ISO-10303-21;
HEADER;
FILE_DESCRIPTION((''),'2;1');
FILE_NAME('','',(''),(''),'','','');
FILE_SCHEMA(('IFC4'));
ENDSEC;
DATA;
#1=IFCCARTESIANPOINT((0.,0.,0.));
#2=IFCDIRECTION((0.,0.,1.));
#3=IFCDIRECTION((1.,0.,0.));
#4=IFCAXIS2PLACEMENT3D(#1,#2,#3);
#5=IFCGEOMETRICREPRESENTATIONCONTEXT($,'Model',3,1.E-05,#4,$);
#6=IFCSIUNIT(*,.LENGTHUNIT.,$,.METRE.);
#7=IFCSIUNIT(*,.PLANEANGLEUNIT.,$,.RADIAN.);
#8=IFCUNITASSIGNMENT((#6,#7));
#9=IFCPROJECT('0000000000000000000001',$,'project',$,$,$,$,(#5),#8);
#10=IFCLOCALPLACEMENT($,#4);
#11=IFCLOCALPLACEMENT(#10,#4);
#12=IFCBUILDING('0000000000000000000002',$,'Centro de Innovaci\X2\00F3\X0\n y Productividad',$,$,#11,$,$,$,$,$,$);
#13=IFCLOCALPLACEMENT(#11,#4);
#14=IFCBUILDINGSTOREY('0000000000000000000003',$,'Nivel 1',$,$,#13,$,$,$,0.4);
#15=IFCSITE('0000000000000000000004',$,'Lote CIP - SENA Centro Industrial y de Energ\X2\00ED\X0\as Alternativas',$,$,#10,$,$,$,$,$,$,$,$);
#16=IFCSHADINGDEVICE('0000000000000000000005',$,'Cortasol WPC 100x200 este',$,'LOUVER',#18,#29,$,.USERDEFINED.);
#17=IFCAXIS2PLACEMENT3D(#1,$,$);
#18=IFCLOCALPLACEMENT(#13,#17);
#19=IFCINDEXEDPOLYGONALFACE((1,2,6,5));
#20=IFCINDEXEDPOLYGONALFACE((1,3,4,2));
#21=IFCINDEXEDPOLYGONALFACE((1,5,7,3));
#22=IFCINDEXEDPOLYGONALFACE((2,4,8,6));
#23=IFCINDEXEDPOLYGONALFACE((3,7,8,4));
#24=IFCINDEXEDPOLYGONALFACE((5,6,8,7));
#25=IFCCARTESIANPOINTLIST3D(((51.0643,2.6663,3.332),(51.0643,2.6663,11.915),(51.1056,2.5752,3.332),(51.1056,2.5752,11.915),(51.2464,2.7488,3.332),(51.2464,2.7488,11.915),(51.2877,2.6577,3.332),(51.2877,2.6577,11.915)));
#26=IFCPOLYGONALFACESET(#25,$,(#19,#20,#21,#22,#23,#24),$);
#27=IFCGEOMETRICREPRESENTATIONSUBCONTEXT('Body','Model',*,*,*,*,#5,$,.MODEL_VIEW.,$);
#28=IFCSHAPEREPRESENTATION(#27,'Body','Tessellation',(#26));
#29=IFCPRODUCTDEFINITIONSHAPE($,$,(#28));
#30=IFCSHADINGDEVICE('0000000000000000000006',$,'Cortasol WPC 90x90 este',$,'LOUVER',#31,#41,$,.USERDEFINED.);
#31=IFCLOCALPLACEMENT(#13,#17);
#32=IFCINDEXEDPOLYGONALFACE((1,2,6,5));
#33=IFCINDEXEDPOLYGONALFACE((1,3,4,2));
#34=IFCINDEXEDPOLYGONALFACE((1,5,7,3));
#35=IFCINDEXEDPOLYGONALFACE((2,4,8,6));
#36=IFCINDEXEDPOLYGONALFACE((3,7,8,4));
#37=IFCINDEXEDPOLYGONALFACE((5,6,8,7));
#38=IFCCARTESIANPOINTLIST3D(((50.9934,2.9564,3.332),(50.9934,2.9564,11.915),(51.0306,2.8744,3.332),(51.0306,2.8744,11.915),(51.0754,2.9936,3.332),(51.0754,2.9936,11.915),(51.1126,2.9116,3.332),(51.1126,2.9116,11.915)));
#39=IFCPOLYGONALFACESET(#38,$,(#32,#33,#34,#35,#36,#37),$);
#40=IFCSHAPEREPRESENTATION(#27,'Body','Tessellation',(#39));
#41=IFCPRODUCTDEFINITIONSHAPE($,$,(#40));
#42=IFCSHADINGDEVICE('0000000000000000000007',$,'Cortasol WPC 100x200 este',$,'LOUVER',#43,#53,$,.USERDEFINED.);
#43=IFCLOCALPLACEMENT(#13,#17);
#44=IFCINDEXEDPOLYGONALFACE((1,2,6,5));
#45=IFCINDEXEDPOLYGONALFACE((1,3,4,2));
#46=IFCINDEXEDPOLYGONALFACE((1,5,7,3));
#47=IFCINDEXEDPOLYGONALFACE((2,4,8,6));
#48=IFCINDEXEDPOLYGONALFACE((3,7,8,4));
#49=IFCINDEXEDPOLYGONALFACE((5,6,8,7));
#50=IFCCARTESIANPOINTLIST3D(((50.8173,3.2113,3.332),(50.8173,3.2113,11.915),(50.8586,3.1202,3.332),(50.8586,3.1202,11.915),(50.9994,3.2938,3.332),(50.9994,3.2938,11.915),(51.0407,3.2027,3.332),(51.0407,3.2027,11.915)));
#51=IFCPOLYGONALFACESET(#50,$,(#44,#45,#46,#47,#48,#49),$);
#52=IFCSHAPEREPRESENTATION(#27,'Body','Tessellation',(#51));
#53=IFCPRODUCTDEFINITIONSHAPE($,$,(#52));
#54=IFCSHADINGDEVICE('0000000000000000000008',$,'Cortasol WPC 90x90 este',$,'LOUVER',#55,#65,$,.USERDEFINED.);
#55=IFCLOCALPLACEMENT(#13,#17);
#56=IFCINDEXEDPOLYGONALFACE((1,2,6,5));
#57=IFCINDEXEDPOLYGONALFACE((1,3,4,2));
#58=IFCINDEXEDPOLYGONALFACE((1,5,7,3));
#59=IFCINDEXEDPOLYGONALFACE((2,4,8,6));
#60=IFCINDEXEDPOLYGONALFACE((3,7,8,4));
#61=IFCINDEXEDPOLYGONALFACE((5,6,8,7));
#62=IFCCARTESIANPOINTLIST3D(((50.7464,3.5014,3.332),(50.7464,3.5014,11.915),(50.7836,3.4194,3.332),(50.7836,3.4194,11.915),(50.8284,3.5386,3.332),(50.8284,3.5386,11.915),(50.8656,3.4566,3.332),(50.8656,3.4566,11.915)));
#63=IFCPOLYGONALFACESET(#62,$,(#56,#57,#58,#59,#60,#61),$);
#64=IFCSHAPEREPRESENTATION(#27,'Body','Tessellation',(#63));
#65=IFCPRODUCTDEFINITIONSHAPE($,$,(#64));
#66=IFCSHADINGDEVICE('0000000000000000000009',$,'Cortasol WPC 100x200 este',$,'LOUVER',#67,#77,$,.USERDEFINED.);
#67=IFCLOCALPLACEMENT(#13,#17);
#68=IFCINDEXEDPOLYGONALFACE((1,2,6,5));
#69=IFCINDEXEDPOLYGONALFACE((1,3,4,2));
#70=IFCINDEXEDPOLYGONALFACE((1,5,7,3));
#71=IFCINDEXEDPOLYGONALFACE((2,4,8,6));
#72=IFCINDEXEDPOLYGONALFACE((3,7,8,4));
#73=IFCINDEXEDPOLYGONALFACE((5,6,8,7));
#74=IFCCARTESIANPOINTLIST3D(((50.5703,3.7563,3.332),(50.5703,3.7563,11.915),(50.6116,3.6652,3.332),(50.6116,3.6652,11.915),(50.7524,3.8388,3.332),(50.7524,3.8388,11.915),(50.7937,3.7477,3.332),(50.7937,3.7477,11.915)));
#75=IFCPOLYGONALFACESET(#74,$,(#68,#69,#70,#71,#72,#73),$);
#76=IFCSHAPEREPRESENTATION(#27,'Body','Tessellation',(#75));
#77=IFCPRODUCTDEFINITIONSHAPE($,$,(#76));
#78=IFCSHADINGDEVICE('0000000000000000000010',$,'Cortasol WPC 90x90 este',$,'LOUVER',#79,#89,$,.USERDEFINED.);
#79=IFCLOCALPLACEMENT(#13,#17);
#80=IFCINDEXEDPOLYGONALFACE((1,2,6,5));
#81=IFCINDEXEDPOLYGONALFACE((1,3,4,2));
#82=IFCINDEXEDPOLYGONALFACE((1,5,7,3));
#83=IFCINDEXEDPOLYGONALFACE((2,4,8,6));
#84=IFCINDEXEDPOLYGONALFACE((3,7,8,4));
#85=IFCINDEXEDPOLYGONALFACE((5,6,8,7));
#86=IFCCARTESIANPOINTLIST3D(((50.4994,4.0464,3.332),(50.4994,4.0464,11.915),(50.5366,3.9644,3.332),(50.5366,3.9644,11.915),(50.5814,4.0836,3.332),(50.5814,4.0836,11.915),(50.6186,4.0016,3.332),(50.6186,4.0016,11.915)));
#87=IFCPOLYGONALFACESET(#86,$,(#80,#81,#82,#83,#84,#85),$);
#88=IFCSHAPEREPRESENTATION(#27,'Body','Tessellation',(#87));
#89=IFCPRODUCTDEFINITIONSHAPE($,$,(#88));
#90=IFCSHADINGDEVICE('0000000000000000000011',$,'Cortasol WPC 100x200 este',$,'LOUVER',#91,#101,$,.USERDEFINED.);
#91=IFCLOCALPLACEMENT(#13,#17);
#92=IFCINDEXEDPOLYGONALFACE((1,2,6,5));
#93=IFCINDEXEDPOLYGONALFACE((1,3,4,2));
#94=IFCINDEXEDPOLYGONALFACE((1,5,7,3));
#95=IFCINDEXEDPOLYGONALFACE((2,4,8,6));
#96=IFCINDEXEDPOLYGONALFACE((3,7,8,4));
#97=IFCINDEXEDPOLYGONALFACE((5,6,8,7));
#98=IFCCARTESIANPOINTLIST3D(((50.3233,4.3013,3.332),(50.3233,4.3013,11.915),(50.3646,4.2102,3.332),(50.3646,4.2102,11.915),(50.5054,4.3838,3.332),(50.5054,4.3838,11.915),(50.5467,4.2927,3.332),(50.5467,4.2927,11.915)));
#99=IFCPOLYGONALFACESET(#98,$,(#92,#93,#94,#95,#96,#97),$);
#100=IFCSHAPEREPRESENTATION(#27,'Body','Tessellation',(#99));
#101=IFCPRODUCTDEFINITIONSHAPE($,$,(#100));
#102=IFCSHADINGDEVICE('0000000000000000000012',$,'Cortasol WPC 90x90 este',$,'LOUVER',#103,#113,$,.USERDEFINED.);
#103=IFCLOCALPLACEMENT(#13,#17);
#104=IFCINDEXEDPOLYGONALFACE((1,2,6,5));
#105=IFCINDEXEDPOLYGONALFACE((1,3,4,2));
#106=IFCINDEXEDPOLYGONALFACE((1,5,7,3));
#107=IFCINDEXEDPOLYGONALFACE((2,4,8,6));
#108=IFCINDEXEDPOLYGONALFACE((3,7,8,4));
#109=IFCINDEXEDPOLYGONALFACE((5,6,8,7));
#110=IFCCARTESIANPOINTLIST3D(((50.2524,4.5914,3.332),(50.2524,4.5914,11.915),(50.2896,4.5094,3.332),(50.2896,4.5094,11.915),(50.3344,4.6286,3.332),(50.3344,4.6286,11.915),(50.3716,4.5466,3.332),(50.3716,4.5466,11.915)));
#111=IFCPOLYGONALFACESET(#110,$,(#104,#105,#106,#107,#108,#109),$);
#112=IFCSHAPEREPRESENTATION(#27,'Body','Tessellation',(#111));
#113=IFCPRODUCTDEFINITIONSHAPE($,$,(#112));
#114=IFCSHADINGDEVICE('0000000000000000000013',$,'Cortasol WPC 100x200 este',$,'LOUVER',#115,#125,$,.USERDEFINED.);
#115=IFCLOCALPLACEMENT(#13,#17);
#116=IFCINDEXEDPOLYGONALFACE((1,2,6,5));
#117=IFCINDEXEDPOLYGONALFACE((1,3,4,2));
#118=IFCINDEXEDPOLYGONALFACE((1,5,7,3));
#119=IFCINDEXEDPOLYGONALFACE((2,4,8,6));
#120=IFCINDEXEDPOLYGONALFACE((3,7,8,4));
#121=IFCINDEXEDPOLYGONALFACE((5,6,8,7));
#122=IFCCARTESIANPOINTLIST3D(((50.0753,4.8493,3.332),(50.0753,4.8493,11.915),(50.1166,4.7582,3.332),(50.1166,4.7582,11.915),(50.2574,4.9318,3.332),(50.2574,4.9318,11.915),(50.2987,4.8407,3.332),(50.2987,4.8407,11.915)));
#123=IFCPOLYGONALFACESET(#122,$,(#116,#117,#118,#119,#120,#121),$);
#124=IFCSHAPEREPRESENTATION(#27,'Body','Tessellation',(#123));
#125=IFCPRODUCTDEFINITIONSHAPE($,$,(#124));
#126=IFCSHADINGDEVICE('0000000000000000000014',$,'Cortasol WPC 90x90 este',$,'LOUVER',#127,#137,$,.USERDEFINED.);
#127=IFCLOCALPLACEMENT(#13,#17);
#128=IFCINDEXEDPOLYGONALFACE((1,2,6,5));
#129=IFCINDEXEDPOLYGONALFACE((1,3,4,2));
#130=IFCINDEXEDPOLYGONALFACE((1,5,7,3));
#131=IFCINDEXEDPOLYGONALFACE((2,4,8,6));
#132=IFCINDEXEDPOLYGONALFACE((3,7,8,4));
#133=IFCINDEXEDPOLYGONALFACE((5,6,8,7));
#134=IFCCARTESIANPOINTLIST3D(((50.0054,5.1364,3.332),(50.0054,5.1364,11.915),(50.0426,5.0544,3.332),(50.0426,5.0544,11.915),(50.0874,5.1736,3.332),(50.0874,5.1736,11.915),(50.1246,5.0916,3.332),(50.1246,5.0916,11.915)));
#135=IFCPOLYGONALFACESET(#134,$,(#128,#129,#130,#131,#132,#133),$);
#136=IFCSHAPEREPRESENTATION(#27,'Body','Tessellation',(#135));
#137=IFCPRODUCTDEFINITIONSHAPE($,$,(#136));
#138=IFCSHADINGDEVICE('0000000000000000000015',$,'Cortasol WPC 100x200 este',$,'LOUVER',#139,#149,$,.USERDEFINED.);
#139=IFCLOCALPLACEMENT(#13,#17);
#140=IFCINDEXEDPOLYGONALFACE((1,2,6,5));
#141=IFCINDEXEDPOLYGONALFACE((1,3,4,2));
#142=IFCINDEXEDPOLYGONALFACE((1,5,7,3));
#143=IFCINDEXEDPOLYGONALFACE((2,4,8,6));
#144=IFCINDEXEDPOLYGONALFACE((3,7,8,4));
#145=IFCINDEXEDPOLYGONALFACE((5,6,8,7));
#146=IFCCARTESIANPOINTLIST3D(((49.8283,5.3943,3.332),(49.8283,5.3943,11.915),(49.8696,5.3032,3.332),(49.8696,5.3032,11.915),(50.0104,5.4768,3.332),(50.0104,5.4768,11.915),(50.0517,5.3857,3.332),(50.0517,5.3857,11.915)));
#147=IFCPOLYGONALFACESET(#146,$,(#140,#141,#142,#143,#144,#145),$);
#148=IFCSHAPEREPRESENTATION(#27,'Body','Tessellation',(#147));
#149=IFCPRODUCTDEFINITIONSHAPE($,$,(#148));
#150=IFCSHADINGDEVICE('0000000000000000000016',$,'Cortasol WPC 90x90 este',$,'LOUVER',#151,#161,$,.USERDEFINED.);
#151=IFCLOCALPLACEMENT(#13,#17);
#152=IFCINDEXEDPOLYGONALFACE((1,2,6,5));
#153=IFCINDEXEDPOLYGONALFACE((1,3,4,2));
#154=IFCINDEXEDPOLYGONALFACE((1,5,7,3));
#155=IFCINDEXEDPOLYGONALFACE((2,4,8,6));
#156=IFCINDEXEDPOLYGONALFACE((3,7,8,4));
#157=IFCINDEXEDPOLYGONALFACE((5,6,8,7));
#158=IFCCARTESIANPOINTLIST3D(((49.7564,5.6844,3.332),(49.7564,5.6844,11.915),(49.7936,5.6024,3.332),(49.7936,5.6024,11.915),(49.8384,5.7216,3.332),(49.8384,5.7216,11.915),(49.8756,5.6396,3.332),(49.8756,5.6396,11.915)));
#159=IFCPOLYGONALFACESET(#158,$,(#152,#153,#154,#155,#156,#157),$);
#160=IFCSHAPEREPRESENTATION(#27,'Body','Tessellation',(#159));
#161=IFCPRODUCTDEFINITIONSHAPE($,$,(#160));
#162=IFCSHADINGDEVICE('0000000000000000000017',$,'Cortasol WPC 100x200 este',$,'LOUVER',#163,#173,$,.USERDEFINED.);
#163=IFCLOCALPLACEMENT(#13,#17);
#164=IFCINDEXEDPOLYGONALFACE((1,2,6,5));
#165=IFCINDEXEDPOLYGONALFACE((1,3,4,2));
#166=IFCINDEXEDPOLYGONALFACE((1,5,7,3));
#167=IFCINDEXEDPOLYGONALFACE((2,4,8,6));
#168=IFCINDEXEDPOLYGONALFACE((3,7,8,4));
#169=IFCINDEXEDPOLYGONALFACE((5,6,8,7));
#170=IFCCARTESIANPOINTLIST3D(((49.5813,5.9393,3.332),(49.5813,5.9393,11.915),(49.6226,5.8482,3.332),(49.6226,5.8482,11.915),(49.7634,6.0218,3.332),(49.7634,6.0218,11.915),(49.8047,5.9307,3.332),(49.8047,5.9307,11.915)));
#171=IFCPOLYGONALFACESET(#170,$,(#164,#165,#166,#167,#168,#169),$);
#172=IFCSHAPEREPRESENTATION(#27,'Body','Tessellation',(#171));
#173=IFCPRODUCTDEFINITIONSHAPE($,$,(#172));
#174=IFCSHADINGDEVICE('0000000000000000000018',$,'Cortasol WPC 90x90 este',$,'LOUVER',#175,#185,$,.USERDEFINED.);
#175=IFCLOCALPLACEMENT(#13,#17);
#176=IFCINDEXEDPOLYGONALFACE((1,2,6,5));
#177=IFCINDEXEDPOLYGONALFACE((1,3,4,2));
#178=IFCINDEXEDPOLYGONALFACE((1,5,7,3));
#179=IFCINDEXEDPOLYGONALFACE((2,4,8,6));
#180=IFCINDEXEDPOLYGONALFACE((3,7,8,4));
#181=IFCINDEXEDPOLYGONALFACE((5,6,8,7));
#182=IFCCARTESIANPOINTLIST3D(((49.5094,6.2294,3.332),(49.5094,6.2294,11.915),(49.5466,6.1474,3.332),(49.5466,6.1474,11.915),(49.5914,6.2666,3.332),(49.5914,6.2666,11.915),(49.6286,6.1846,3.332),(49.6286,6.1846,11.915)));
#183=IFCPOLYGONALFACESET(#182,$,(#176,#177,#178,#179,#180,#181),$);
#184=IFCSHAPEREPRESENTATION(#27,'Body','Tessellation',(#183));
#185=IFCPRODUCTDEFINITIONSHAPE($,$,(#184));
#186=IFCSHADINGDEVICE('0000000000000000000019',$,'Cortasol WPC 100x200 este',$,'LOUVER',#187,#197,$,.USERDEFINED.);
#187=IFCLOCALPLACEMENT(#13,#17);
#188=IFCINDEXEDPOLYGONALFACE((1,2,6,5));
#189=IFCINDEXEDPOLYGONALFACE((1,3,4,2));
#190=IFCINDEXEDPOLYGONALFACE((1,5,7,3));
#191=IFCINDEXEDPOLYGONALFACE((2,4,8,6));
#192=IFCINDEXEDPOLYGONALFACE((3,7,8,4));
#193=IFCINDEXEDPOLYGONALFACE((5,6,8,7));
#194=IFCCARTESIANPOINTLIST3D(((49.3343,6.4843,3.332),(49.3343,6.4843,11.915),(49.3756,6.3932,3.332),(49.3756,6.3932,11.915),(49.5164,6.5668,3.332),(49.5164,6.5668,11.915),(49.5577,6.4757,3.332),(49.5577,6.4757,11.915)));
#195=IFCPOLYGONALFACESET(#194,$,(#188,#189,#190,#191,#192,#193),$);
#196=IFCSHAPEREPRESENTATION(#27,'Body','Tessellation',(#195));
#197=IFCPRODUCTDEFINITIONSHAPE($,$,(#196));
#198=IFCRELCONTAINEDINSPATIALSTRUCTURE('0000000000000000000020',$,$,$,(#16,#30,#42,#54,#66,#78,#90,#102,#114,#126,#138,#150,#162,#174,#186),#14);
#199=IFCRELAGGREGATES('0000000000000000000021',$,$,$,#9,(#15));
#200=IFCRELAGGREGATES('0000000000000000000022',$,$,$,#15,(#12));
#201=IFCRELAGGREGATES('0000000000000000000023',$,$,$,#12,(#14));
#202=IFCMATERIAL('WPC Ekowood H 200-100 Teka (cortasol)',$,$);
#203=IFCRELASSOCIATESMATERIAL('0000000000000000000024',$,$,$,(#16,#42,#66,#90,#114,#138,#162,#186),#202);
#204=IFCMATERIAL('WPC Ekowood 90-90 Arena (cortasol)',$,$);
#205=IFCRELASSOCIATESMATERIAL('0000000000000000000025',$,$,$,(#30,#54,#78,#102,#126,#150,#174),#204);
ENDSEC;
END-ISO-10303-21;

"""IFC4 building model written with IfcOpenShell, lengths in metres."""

from ifc_helpers import new_model, si_unit, frame, origin_with_axes, place, context, subcontext, project, spatial, polyline, outline, extrude, material, element, save


model = new_model("IFC4")

# Units and contexts
model_context = context("Model", 3, precision=1e-05, world=origin_with_axes())
body_context = subcontext(model_context, "Body", "Model", "MODEL_VIEW")
ifc_project = project(units=[si_unit("LENGTHUNIT", "METRE"), si_unit("PLANEANGLEUNIT", "RADIAN")], contexts=[model_context])

# Site, building, storey
site_placement = place(None, origin_with_axes())
site = spatial("IfcSite", under=ifc_project, at=site_placement, Name="Lote CIP - SENA Centro Industrial y de Energías Alternativas")
building_placement = place(site_placement, origin_with_axes())
building = spatial("IfcBuilding", under=site, at=building_placement, Name="Centro de Innovación y Productividad")
storey_placement = place(building_placement, origin_with_axes())
storey = spatial("IfcBuildingStorey", under=building, at=storey_placement, Name="Nivel 1", Elevation=0.4)

# Shading devices
ifc_material_1 = material(Name="WPC Ekowood H 200-100 Teka (cortasol)")
shading_device_1_placement = place(storey_placement, origin_with_axes())
element("IfcShadingDevice", 1, at=shading_device_1_placement, inside=storey, material=ifc_material_1, Name="Cortasol WPC 100x200 este", ObjectType="LOUVER", PredefinedType="USERDEFINED", context=body_context, shape_type="SweptSolid", body=[
    extrude(outline(polyline([(51.0643, 2.6663), (51.2464, 2.7488), (51.2877, 2.6577), (51.1056, 2.5752), (51.0643, 2.6663)])), frame((0.0, 0.0, 3.332)), (0.0, 0.0, 1.0), 8.583),
])
ifc_material_2 = material(Name="WPC Ekowood 90-90 Arena (cortasol)")
shading_device_2_placement = place(storey_placement, origin_with_axes())
element("IfcShadingDevice", 2, at=shading_device_2_placement, inside=storey, material=ifc_material_2, Name="Cortasol WPC 90x90 este", ObjectType="LOUVER", PredefinedType="USERDEFINED", context=body_context, shape_type="SweptSolid", body=[
    extrude(outline(polyline([(50.9934, 2.9564), (51.0754, 2.9936), (51.1126, 2.9116), (51.0306, 2.8744), (50.9934, 2.9564)])), frame((0.0, 0.0, 3.332)), (0.0, 0.0, 1.0), 8.583),
])
shading_device_3_placement = place(storey_placement, origin_with_axes())
element("IfcShadingDevice", 3, at=shading_device_3_placement, inside=storey, material=ifc_material_1, Name="Cortasol WPC 100x200 este", ObjectType="LOUVER", PredefinedType="USERDEFINED", context=body_context, shape_type="SweptSolid", body=[
    extrude(outline(polyline([(50.8173, 3.2113), (50.9994, 3.2938), (51.0407, 3.2027), (50.8586, 3.1202), (50.8173, 3.2113)])), frame((0.0, 0.0, 3.332)), (0.0, 0.0, 1.0), 8.583),
])
shading_device_4_placement = place(storey_placement, origin_with_axes())
element("IfcShadingDevice", 4, at=shading_device_4_placement, inside=storey, material=ifc_material_2, Name="Cortasol WPC 90x90 este", ObjectType="LOUVER", PredefinedType="USERDEFINED", context=body_context, shape_type="SweptSolid", body=[
    extrude(outline(polyline([(50.7464, 3.5014), (50.8284, 3.5386), (50.8656, 3.4566), (50.7836, 3.4194), (50.7464, 3.5014)])), frame((0.0, 0.0, 3.332)), (0.0, 0.0, 1.0), 8.583),
])
shading_device_5_placement = place(storey_placement, origin_with_axes())
element("IfcShadingDevice", 5, at=shading_device_5_placement, inside=storey, material=ifc_material_1, Name="Cortasol WPC 100x200 este", ObjectType="LOUVER", PredefinedType="USERDEFINED", context=body_context, shape_type="SweptSolid", body=[
    extrude(outline(polyline([(50.5703, 3.7563), (50.7524, 3.8388), (50.7937, 3.7477), (50.6116, 3.6652), (50.5703, 3.7563)])), frame((0.0, 0.0, 3.332)), (0.0, 0.0, 1.0), 8.583),
])
shading_device_6_placement = place(storey_placement, origin_with_axes())
element("IfcShadingDevice", 6, at=shading_device_6_placement, inside=storey, material=ifc_material_2, Name="Cortasol WPC 90x90 este", ObjectType="LOUVER", PredefinedType="USERDEFINED", context=body_context, shape_type="SweptSolid", body=[
    extrude(outline(polyline([(50.4994, 4.0464), (50.5814, 4.0836), (50.6186, 4.0016), (50.5366, 3.9644), (50.4994, 4.0464)])), frame((0.0, 0.0, 3.332)), (0.0, 0.0, 1.0), 8.583),
])
shading_device_7_placement = place(storey_placement, origin_with_axes())
element("IfcShadingDevice", 7, at=shading_device_7_placement, inside=storey, material=ifc_material_1, Name="Cortasol WPC 100x200 este", ObjectType="LOUVER", PredefinedType="USERDEFINED", context=body_context, shape_type="SweptSolid", body=[
    extrude(outline(polyline([(50.3233, 4.3013), (50.5054, 4.3838), (50.5467, 4.2927), (50.3646, 4.2102), (50.3233, 4.3013)])), frame((0.0, 0.0, 3.332)), (0.0, 0.0, 1.0), 8.583),
])
shading_device_8_placement = place(storey_placement, origin_with_axes())
element("IfcShadingDevice", 8, at=shading_device_8_placement, inside=storey, material=ifc_material_2, Name="Cortasol WPC 90x90 este", ObjectType="LOUVER", PredefinedType="USERDEFINED", context=body_context, shape_type="SweptSolid", body=[
    extrude(outline(polyline([(50.2524, 4.5914), (50.3344, 4.6286), (50.3716, 4.5466), (50.2896, 4.5094), (50.2524, 4.5914)])), frame((0.0, 0.0, 3.332)), (0.0, 0.0, 1.0), 8.583),
])
shading_device_9_placement = place(storey_placement, origin_with_axes())
element("IfcShadingDevice", 9, at=shading_device_9_placement, inside=storey, material=ifc_material_1, Name="Cortasol WPC 100x200 este", ObjectType="LOUVER", PredefinedType="USERDEFINED", context=body_context, shape_type="SweptSolid", body=[
    extrude(outline(polyline([(50.0753, 4.8493), (50.2574, 4.9318), (50.2987, 4.8407), (50.1166, 4.7582), (50.0753, 4.8493)])), frame((0.0, 0.0, 3.332)), (0.0, 0.0, 1.0), 8.583),
])
shading_device_10_placement = place(storey_placement, origin_with_axes())
element("IfcShadingDevice", 10, at=shading_device_10_placement, inside=storey, material=ifc_material_2, Name="Cortasol WPC 90x90 este", ObjectType="LOUVER", PredefinedType="USERDEFINED", context=body_context, shape_type="SweptSolid", body=[
    extrude(outline(polyline([(50.0054, 5.1364), (50.0874, 5.1736), (50.1246, 5.0916), (50.0426, 5.0544), (50.0054, 5.1364)])), frame((0.0, 0.0, 3.332)), (0.0, 0.0, 1.0), 8.583),
])
shading_device_11_placement = place(storey_placement, origin_with_axes())
element("IfcShadingDevice", 11, at=shading_device_11_placement, inside=storey, material=ifc_material_1, Name="Cortasol WPC 100x200 este", ObjectType="LOUVER", PredefinedType="USERDEFINED", context=body_context, shape_type="SweptSolid", body=[
    extrude(outline(polyline([(49.8283, 5.3943), (50.0104, 5.4768), (50.0517, 5.3857), (49.8696, 5.3032), (49.8283, 5.3943)])), frame((0.0, 0.0, 3.332)), (0.0, 0.0, 1.0), 8.583),
])
shading_device_12_placement = place(storey_placement, origin_with_axes())
element("IfcShadingDevice", 12, at=shading_device_12_placement, inside=storey, material=ifc_material_2, Name="Cortasol WPC 90x90 este", ObjectType="LOUVER", PredefinedType="USERDEFINED", context=body_context, shape_type="SweptSolid", body=[
    extrude(outline(polyline([(49.7564, 5.6844), (49.8384, 5.7216), (49.8756, 5.6396), (49.7936, 5.6024), (49.7564, 5.6844)])), frame((0.0, 0.0, 3.332)), (0.0, 0.0, 1.0), 8.583),
])
shading_device_13_placement = place(storey_placement, origin_with_axes())
element("IfcShadingDevice", 13, at=shading_device_13_placement, inside=storey, material=ifc_material_1, Name="Cortasol WPC 100x200 este", ObjectType="LOUVER", PredefinedType="USERDEFINED", context=body_context, shape_type="SweptSolid", body=[
    extrude(outline(polyline([(49.5813, 5.9393), (49.7634, 6.0218), (49.8047, 5.9307), (49.6226, 5.8482), (49.5813, 5.9393)])), frame((0.0, 0.0, 3.332)), (0.0, 0.0, 1.0), 8.583),
])
shading_device_14_placement = place(storey_placement, origin_with_axes())
element("IfcShadingDevice", 14, at=shading_device_14_placement, inside=storey, material=ifc_material_2, Name="Cortasol WPC 90x90 este", ObjectType="LOUVER", PredefinedType="USERDEFINED", context=body_context, shape_type="SweptSolid", body=[
    extrude(outline(polyline([(49.5094, 6.2294), (49.5914, 6.2666), (49.6286, 6.1846), (49.5466, 6.1474), (49.5094, 6.2294)])), frame((0.0, 0.0, 3.332)), (0.0, 0.0, 1.0), 8.583),
])
shading_device_15_placement = place(storey_placement, origin_with_axes())
element("IfcShadingDevice", 15, at=shading_device_15_placement, inside=storey, material=ifc_material_1, Name="Cortasol WPC 100x200 este", ObjectType="LOUVER", PredefinedType="USERDEFINED", context=body_context, shape_type="SweptSolid", body=[
    extrude(outline(polyline([(49.3343, 6.4843), (49.5164, 6.5668), (49.5577, 6.4757), (49.3756, 6.3932), (49.3343, 6.4843)])), frame((0.0, 0.0, 3.332)), (0.0, 0.0, 1.0), 8.583),
])

save(model, "model.ifc")
